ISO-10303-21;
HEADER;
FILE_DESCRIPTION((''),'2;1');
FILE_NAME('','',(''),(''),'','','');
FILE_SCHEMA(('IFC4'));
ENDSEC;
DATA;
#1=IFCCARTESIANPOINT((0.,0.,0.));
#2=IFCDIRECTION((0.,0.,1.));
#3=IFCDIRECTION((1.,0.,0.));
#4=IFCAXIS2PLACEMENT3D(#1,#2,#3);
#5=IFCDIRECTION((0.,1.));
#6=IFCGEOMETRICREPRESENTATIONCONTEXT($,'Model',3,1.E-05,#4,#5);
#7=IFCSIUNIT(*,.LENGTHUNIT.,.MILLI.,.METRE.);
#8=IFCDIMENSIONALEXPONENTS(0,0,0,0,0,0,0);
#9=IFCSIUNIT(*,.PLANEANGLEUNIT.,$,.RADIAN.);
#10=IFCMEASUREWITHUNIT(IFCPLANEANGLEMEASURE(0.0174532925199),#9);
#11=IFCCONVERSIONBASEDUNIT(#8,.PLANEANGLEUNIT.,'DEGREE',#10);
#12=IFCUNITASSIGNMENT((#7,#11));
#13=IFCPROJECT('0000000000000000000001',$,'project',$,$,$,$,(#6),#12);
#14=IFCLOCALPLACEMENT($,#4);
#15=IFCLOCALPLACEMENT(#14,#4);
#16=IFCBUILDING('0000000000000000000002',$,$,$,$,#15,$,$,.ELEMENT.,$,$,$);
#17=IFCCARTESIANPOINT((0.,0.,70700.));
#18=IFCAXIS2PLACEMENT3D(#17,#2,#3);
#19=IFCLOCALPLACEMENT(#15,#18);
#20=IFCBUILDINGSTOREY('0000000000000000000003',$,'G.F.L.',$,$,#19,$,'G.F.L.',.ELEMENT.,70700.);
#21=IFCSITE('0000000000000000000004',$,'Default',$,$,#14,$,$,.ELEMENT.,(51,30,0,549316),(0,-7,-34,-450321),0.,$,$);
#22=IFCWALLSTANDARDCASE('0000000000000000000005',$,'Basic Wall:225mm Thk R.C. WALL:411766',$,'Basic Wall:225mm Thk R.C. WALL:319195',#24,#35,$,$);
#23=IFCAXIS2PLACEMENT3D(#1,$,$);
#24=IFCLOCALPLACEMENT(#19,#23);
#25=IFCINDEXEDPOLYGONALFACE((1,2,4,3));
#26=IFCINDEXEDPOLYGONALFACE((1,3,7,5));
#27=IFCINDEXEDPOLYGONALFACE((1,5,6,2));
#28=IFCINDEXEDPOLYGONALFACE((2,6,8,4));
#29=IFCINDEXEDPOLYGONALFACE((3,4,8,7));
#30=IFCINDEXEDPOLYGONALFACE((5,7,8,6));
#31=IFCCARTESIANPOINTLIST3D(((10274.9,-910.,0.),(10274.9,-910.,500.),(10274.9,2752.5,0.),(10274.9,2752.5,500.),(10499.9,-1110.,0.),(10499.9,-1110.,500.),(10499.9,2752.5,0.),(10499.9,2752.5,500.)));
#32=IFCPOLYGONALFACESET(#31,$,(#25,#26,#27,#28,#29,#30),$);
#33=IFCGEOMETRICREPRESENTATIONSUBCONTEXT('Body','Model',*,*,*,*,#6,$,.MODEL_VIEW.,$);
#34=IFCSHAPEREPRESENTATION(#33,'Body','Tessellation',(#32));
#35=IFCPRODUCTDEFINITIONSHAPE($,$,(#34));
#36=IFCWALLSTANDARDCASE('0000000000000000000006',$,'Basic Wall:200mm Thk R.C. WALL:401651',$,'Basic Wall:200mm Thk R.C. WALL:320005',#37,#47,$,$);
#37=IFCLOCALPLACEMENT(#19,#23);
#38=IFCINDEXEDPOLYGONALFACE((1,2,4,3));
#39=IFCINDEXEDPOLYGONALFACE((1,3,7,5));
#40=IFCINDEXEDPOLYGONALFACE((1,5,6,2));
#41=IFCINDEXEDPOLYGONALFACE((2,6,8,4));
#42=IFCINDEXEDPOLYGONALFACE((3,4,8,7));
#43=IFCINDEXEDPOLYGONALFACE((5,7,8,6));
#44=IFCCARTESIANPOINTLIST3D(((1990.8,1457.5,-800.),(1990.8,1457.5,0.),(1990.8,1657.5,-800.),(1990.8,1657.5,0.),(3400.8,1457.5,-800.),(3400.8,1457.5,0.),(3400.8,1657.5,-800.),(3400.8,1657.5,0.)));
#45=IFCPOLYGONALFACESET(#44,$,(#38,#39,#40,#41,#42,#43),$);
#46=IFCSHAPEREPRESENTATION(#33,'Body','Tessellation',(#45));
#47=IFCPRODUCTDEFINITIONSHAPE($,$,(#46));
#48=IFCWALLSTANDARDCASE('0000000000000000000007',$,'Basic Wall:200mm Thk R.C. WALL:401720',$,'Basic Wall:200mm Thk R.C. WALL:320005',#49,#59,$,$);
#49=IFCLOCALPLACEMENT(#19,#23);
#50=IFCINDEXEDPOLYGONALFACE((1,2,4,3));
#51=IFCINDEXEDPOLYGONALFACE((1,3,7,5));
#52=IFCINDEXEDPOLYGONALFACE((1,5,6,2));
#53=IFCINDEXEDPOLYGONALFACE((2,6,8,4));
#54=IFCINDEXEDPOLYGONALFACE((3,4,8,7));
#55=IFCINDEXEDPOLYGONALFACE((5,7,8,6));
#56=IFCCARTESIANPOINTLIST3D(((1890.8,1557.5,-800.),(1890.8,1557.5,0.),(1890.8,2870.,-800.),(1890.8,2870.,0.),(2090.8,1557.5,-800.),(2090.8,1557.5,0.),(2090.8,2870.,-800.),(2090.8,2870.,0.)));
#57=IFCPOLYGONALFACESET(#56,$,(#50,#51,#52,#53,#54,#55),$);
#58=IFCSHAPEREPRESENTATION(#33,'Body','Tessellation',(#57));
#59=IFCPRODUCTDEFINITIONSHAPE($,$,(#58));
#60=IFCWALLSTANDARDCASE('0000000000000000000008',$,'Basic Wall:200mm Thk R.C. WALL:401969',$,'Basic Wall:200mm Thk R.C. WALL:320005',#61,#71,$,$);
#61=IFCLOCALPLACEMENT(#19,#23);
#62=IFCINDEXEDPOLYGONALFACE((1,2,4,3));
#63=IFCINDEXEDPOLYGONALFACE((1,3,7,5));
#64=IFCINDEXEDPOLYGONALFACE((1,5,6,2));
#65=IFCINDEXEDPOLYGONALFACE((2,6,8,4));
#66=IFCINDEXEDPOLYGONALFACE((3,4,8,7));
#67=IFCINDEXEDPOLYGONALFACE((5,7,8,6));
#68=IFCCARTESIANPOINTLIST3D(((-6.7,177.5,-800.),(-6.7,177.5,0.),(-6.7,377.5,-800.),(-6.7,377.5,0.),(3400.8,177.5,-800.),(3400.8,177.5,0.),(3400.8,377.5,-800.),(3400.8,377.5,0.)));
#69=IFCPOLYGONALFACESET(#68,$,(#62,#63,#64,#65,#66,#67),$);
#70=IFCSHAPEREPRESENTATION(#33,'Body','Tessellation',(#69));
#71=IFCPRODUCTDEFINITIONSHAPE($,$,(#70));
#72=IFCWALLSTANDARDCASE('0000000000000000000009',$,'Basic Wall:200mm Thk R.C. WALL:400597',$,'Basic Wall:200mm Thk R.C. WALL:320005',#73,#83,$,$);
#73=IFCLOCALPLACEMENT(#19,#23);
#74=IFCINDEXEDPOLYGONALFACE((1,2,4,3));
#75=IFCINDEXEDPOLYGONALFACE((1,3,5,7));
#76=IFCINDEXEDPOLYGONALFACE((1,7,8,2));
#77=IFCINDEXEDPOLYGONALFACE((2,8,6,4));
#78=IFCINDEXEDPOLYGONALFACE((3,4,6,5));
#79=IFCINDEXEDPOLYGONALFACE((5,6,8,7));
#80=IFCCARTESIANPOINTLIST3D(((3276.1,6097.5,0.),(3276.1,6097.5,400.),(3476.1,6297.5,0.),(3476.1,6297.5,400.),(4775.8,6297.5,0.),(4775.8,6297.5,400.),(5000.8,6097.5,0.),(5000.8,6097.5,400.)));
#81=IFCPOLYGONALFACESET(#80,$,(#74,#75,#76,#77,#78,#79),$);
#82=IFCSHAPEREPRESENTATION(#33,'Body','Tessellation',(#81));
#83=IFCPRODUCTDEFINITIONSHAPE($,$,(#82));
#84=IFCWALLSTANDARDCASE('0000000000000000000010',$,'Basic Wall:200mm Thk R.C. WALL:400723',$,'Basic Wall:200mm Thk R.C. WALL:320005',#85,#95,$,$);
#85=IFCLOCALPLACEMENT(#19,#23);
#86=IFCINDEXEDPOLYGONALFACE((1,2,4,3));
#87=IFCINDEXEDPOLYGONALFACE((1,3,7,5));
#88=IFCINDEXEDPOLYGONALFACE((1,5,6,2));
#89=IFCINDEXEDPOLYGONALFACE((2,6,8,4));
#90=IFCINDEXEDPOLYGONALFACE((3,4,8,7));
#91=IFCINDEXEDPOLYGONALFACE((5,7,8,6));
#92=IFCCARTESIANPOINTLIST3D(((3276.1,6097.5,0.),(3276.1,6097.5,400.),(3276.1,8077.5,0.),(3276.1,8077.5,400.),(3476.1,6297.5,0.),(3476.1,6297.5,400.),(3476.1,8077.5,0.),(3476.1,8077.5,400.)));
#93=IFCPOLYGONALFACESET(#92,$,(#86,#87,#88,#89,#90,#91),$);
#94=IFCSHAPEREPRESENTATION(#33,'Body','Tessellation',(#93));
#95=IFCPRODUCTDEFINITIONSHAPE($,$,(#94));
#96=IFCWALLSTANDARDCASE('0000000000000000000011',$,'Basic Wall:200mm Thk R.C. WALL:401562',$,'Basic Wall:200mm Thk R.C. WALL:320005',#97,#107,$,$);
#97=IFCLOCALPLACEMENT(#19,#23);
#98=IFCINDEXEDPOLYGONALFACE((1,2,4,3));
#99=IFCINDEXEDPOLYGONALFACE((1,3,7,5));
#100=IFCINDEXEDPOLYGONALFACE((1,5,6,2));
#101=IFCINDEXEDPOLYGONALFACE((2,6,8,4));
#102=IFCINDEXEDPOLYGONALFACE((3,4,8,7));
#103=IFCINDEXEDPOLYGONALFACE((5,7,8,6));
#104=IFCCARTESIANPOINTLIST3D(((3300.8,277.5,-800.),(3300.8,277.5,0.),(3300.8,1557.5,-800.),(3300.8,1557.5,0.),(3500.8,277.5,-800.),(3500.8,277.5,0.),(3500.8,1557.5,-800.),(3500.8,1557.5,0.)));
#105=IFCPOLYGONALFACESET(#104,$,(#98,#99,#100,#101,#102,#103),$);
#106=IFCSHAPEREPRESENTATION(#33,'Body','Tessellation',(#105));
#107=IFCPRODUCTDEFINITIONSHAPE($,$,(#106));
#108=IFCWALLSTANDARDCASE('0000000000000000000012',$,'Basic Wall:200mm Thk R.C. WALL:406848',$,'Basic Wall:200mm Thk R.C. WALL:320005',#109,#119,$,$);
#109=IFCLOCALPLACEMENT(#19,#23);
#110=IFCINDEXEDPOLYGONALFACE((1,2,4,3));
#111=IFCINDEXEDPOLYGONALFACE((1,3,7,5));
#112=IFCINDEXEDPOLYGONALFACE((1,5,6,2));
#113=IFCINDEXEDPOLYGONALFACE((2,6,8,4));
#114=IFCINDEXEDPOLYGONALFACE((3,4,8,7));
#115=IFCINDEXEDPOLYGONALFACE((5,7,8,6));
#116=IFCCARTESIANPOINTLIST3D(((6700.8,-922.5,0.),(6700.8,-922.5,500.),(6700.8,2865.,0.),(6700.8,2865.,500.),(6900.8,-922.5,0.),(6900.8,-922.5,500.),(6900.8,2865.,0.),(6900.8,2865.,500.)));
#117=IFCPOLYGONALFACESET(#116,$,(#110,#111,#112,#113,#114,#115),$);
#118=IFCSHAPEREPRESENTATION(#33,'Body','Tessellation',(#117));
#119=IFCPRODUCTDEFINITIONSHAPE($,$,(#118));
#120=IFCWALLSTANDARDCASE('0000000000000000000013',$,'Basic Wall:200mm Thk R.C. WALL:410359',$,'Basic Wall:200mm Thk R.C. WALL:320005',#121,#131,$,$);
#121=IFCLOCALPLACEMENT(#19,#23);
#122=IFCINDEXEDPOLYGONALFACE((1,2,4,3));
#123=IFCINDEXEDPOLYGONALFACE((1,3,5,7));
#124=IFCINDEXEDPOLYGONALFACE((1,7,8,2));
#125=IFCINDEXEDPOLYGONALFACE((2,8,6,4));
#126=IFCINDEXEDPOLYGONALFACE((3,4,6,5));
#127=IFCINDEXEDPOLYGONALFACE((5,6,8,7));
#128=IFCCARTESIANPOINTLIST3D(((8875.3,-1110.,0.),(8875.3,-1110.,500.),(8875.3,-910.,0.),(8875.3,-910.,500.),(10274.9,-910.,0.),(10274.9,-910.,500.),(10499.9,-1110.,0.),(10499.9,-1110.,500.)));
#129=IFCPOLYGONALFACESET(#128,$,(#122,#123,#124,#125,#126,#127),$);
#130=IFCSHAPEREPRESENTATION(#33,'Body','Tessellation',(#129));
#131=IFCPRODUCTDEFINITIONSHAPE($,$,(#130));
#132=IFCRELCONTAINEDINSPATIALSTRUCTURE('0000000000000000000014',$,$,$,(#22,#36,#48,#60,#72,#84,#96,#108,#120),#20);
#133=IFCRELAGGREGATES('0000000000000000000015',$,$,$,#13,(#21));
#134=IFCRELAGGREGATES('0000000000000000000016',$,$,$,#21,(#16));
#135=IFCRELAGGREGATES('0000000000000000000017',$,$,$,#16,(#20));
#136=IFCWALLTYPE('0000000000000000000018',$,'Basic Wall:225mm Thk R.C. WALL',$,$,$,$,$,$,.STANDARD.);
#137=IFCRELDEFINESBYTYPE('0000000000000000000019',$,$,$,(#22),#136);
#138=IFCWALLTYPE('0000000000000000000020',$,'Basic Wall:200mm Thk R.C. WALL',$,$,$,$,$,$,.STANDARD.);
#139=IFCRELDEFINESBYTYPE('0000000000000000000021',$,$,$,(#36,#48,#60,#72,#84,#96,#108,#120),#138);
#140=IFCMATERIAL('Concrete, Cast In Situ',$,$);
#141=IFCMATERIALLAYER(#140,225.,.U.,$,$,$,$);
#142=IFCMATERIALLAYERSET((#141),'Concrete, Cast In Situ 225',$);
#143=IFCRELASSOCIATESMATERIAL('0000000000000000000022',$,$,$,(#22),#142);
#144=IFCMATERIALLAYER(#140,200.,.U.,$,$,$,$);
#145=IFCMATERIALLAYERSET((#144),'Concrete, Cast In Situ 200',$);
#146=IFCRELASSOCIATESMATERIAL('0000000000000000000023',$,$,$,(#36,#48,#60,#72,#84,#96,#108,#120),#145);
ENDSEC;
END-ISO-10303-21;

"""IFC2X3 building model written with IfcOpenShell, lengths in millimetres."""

from ifc_helpers import new_model, entity, si_unit, converted_unit, direction, frame, origin_with_axes, place, context, subcontext, project, spatial, polyline, outline, extrude, material, layer, layer_set, layer_usage, type_object, element, save


model = new_model("IFC2X3")

# Units and contexts
model_context = context("Model", 3, precision=1e-05, world=origin_with_axes(), true_north=direction((0.0, 1.0)))
body_context = subcontext(model_context, "Body", "Model", "MODEL_VIEW")
ifc_project = project(units=[si_unit("LENGTHUNIT", "METRE", prefix="MILLI"), converted_unit("PLANEANGLEUNIT", "DEGREE", entity("IfcPlaneAngleMeasure", 0.0174532925199), si_unit("PLANEANGLEUNIT", "RADIAN"), dimensions=[0, 0, 0, 0, 0, 0, 0])], contexts=[model_context])

# Site, building, storey
site_placement = place(None, origin_with_axes())
site = spatial("IfcSite", under=ifc_project, at=site_placement, Name="Default", CompositionType="ELEMENT", RefLatitude=(51, 30, 0, 549316), RefLongitude=(0, -7, -34, -450321), RefElevation=0.0)
building_placement = place(site_placement, origin_with_axes())
building = spatial("IfcBuilding", under=site, at=building_placement, CompositionType="ELEMENT")
storey_placement = place(building_placement, frame((0.0, 0.0, 70700.0), z_axis=(0.0, 0.0, 1.0), x_axis=(1.0, 0.0, 0.0)))
storey = spatial("IfcBuildingStorey", under=building, at=storey_placement, Name="G.F.L.", LongName="G.F.L.", CompositionType="ELEMENT", Elevation=70700.0)

# Shared definitions
ifc_material_1 = material(Name="Concrete, Cast In Situ")
ifc_layer_1 = layer(ifc_material_1, 200.0, ventilated="UNKNOWN")
ifc_layer_set_1 = layer_set([ifc_layer_1], Name="Concrete, Cast In Situ 200")

# Walls
ifc_layer_2 = layer(ifc_material_1, 225.0, ventilated="UNKNOWN")
ifc_layer_set_2 = layer_set([ifc_layer_2], Name="Concrete, Cast In Situ 225")
wall_type_1 = type_object("IfcWallType", Name="Basic Wall:225mm Thk R.C. WALL", PredefinedType="STANDARD")
ifc_layer_usage_1 = layer_usage(ifc_layer_set_2, "AXIS2", "POSITIVE", -112.5)
wall_1_placement = place(storey_placement, frame((10387.4, 2865.0, 0.0), z_axis=(0.0, 0.0, 1.0), x_axis=(0.0, -1.0, 0.0)))
element("IfcWallStandardCase", 1, at=wall_1_placement, inside=storey, type_object=wall_type_1, material=ifc_layer_usage_1, Name="Basic Wall:225mm Thk R.C. WALL:411766", ObjectType="Basic Wall:225mm Thk R.C. WALL:319195", context=body_context, shape_type="SweptSolid", body=[
    extrude(outline(polyline([(112.5, -112.5), (3775.0, -112.5), (3975.0, 112.5), (112.5, 112.5), (112.5, -112.5)])), origin_with_axes(), (0.0, 0.0, 1.0), 500.0),
])
ifc_layer_usage_2 = layer_usage(ifc_layer_set_1, "AXIS2", "POSITIVE", -100.0)
wall_type_2 = type_object("IfcWallType", Name="Basic Wall:200mm Thk R.C. WALL", PredefinedType="STANDARD")
wall_2_placement = place(storey_placement, frame((3400.8, 1557.5, -800.0), z_axis=(0.0, 0.0, 1.0), x_axis=(-1.0, 0.0, 0.0)))
element("IfcWallStandardCase", 2, at=wall_2_placement, inside=storey, type_object=wall_type_2, material=ifc_layer_usage_2, Name="Basic Wall:200mm Thk R.C. WALL:401651", ObjectType="Basic Wall:200mm Thk R.C. WALL:320005", context=body_context, shape_type="SweptSolid", body=[
    extrude(outline(polyline([(0.0, -100.0), (1410.0, -100.0), (1410.0, 100.0), (0.0, 100.0), (0.0, -100.0)])), origin_with_axes(), (0.0, 0.0, 1.0), 800.0),
])
ifc_layer_usage_3 = layer_usage(ifc_layer_set_1, "AXIS2", "POSITIVE", -100.0)
wall_3_placement = place(storey_placement, frame((1990.8, 1557.5, -800.0), z_axis=(0.0, 0.0, 1.0), x_axis=(0.0, 1.0, 0.0)))
element("IfcWallStandardCase", 3, at=wall_3_placement, inside=storey, type_object=wall_type_2, material=ifc_layer_usage_3, Name="Basic Wall:200mm Thk R.C. WALL:401720", ObjectType="Basic Wall:200mm Thk R.C. WALL:320005", context=body_context, shape_type="SweptSolid", body=[
    extrude(outline(polyline([(0.0, -100.0), (1312.5, -100.0), (1312.5, 100.0), (0.0, 100.0), (0.0, -100.0)])), origin_with_axes(), (0.0, 0.0, 1.0), 800.0),
])
ifc_layer_usage_4 = layer_usage(ifc_layer_set_1, "AXIS2", "POSITIVE", -100.0)
wall_4_placement = place(storey_placement, frame((-6.7, 277.5, -800.0), z_axis=(0.0, 0.0, 1.0), x_axis=(1.0, 0.0, 0.0)))
element("IfcWallStandardCase", 4, at=wall_4_placement, inside=storey, type_object=wall_type_2, material=ifc_layer_usage_4, Name="Basic Wall:200mm Thk R.C. WALL:401969", ObjectType="Basic Wall:200mm Thk R.C. WALL:320005", context=body_context, shape_type="SweptSolid", body=[
    extrude(outline(polyline([(0.0, -100.0), (3407.5, -100.0), (3407.5, 100.0), (0.0, 100.0), (0.0, -100.0)])), origin_with_axes(), (0.0, 0.0, 1.0), 800.0),
])
ifc_layer_usage_5 = layer_usage(ifc_layer_set_1, "AXIS2", "POSITIVE", -100.0)
wall_5_placement = place(storey_placement, frame((4888.3, 6197.5, 0.0), z_axis=(0.0, 0.0, 1.0), x_axis=(-1.0, 0.0, 0.0)))
element("IfcWallStandardCase", 5, at=wall_5_placement, inside=storey, type_object=wall_type_2, material=ifc_layer_usage_5, Name="Basic Wall:200mm Thk R.C. WALL:400597", ObjectType="Basic Wall:200mm Thk R.C. WALL:320005", context=body_context, shape_type="SweptSolid", body=[
    extrude(outline(polyline([(112.5, -100.0), (1412.2, -100.0), (1612.2, 100.0), (-112.5, 100.0), (112.5, -100.0)])), origin_with_axes(), (0.0, 0.0, 1.0), 400.0),
])
ifc_layer_usage_6 = layer_usage(ifc_layer_set_1, "AXIS2", "POSITIVE", -100.0)
wall_6_placement = place(storey_placement, frame((3376.1, 6197.5, 0.0), z_axis=(0.0, 0.0, 1.0), x_axis=(0.0, 1.0, 0.0)))
element("IfcWallStandardCase", 6, at=wall_6_placement, inside=storey, type_object=wall_type_2, material=ifc_layer_usage_6, Name="Basic Wall:200mm Thk R.C. WALL:400723", ObjectType="Basic Wall:200mm Thk R.C. WALL:320005", context=body_context, shape_type="SweptSolid", body=[
    extrude(outline(polyline([(100.0, -100.0), (1879.9, -100.0), (1879.9, 100.0), (-100.0, 100.0), (100.0, -100.0)])), origin_with_axes(), (0.0, 0.0, 1.0), 400.0),
])
ifc_layer_usage_7 = layer_usage(ifc_layer_set_1, "AXIS2", "POSITIVE", -100.0)
wall_7_placement = place(storey_placement, frame((3400.8, 277.5, -800.0), z_axis=(0.0, 0.0, 1.0), x_axis=(0.0, 1.0, 0.0)))
element("IfcWallStandardCase", 7, at=wall_7_placement, inside=storey, type_object=wall_type_2, material=ifc_layer_usage_7, Name="Basic Wall:200mm Thk R.C. WALL:401562", ObjectType="Basic Wall:200mm Thk R.C. WALL:320005", context=body_context, shape_type="SweptSolid", body=[
    extrude(outline(polyline([(0.0, -100.0), (1280.0, -100.0), (1280.0, 100.0), (0.0, 100.0), (0.0, -100.0)])), origin_with_axes(), (0.0, 0.0, 1.0), 800.0),
])
ifc_layer_usage_8 = layer_usage(ifc_layer_set_1, "AXIS2", "POSITIVE", -100.0)
wall_8_placement = place(storey_placement, frame((6800.8, 2865.0, 0.0), z_axis=(0.0, 0.0, 1.0), x_axis=(0.0, -1.0, 0.0)))
element("IfcWallStandardCase", 8, at=wall_8_placement, inside=storey, type_object=wall_type_2, material=ifc_layer_usage_8, Name="Basic Wall:200mm Thk R.C. WALL:406848", ObjectType="Basic Wall:200mm Thk R.C. WALL:320005", context=body_context, shape_type="SweptSolid", body=[
    extrude(outline(polyline([(0.0, -100.0), (3787.5, -100.0), (3787.5, 100.0), (0.0, 100.0), (0.0, -100.0)])), origin_with_axes(), (0.0, 0.0, 1.0), 500.0),
])
ifc_layer_usage_9 = layer_usage(ifc_layer_set_1, "AXIS2", "POSITIVE", -100.0)
wall_9_placement = place(storey_placement, frame((8875.3, -1010.0, 0.0), z_axis=(0.0, 0.0, 1.0), x_axis=(1.0, 0.0, 0.0)))
element("IfcWallStandardCase", 9, at=wall_9_placement, inside=storey, type_object=wall_type_2, material=ifc_layer_usage_9, Name="Basic Wall:200mm Thk R.C. WALL:410359", ObjectType="Basic Wall:200mm Thk R.C. WALL:320005", context=body_context, shape_type="SweptSolid", body=[
    extrude(outline(polyline([(0.0, -100.0), (1624.5, -100.0), (1399.5, 100.0), (0.0, 100.0), (0.0, -100.0)])), origin_with_axes(), (0.0, 0.0, 1.0), 500.0),
])

save(model, "model.ifc")
